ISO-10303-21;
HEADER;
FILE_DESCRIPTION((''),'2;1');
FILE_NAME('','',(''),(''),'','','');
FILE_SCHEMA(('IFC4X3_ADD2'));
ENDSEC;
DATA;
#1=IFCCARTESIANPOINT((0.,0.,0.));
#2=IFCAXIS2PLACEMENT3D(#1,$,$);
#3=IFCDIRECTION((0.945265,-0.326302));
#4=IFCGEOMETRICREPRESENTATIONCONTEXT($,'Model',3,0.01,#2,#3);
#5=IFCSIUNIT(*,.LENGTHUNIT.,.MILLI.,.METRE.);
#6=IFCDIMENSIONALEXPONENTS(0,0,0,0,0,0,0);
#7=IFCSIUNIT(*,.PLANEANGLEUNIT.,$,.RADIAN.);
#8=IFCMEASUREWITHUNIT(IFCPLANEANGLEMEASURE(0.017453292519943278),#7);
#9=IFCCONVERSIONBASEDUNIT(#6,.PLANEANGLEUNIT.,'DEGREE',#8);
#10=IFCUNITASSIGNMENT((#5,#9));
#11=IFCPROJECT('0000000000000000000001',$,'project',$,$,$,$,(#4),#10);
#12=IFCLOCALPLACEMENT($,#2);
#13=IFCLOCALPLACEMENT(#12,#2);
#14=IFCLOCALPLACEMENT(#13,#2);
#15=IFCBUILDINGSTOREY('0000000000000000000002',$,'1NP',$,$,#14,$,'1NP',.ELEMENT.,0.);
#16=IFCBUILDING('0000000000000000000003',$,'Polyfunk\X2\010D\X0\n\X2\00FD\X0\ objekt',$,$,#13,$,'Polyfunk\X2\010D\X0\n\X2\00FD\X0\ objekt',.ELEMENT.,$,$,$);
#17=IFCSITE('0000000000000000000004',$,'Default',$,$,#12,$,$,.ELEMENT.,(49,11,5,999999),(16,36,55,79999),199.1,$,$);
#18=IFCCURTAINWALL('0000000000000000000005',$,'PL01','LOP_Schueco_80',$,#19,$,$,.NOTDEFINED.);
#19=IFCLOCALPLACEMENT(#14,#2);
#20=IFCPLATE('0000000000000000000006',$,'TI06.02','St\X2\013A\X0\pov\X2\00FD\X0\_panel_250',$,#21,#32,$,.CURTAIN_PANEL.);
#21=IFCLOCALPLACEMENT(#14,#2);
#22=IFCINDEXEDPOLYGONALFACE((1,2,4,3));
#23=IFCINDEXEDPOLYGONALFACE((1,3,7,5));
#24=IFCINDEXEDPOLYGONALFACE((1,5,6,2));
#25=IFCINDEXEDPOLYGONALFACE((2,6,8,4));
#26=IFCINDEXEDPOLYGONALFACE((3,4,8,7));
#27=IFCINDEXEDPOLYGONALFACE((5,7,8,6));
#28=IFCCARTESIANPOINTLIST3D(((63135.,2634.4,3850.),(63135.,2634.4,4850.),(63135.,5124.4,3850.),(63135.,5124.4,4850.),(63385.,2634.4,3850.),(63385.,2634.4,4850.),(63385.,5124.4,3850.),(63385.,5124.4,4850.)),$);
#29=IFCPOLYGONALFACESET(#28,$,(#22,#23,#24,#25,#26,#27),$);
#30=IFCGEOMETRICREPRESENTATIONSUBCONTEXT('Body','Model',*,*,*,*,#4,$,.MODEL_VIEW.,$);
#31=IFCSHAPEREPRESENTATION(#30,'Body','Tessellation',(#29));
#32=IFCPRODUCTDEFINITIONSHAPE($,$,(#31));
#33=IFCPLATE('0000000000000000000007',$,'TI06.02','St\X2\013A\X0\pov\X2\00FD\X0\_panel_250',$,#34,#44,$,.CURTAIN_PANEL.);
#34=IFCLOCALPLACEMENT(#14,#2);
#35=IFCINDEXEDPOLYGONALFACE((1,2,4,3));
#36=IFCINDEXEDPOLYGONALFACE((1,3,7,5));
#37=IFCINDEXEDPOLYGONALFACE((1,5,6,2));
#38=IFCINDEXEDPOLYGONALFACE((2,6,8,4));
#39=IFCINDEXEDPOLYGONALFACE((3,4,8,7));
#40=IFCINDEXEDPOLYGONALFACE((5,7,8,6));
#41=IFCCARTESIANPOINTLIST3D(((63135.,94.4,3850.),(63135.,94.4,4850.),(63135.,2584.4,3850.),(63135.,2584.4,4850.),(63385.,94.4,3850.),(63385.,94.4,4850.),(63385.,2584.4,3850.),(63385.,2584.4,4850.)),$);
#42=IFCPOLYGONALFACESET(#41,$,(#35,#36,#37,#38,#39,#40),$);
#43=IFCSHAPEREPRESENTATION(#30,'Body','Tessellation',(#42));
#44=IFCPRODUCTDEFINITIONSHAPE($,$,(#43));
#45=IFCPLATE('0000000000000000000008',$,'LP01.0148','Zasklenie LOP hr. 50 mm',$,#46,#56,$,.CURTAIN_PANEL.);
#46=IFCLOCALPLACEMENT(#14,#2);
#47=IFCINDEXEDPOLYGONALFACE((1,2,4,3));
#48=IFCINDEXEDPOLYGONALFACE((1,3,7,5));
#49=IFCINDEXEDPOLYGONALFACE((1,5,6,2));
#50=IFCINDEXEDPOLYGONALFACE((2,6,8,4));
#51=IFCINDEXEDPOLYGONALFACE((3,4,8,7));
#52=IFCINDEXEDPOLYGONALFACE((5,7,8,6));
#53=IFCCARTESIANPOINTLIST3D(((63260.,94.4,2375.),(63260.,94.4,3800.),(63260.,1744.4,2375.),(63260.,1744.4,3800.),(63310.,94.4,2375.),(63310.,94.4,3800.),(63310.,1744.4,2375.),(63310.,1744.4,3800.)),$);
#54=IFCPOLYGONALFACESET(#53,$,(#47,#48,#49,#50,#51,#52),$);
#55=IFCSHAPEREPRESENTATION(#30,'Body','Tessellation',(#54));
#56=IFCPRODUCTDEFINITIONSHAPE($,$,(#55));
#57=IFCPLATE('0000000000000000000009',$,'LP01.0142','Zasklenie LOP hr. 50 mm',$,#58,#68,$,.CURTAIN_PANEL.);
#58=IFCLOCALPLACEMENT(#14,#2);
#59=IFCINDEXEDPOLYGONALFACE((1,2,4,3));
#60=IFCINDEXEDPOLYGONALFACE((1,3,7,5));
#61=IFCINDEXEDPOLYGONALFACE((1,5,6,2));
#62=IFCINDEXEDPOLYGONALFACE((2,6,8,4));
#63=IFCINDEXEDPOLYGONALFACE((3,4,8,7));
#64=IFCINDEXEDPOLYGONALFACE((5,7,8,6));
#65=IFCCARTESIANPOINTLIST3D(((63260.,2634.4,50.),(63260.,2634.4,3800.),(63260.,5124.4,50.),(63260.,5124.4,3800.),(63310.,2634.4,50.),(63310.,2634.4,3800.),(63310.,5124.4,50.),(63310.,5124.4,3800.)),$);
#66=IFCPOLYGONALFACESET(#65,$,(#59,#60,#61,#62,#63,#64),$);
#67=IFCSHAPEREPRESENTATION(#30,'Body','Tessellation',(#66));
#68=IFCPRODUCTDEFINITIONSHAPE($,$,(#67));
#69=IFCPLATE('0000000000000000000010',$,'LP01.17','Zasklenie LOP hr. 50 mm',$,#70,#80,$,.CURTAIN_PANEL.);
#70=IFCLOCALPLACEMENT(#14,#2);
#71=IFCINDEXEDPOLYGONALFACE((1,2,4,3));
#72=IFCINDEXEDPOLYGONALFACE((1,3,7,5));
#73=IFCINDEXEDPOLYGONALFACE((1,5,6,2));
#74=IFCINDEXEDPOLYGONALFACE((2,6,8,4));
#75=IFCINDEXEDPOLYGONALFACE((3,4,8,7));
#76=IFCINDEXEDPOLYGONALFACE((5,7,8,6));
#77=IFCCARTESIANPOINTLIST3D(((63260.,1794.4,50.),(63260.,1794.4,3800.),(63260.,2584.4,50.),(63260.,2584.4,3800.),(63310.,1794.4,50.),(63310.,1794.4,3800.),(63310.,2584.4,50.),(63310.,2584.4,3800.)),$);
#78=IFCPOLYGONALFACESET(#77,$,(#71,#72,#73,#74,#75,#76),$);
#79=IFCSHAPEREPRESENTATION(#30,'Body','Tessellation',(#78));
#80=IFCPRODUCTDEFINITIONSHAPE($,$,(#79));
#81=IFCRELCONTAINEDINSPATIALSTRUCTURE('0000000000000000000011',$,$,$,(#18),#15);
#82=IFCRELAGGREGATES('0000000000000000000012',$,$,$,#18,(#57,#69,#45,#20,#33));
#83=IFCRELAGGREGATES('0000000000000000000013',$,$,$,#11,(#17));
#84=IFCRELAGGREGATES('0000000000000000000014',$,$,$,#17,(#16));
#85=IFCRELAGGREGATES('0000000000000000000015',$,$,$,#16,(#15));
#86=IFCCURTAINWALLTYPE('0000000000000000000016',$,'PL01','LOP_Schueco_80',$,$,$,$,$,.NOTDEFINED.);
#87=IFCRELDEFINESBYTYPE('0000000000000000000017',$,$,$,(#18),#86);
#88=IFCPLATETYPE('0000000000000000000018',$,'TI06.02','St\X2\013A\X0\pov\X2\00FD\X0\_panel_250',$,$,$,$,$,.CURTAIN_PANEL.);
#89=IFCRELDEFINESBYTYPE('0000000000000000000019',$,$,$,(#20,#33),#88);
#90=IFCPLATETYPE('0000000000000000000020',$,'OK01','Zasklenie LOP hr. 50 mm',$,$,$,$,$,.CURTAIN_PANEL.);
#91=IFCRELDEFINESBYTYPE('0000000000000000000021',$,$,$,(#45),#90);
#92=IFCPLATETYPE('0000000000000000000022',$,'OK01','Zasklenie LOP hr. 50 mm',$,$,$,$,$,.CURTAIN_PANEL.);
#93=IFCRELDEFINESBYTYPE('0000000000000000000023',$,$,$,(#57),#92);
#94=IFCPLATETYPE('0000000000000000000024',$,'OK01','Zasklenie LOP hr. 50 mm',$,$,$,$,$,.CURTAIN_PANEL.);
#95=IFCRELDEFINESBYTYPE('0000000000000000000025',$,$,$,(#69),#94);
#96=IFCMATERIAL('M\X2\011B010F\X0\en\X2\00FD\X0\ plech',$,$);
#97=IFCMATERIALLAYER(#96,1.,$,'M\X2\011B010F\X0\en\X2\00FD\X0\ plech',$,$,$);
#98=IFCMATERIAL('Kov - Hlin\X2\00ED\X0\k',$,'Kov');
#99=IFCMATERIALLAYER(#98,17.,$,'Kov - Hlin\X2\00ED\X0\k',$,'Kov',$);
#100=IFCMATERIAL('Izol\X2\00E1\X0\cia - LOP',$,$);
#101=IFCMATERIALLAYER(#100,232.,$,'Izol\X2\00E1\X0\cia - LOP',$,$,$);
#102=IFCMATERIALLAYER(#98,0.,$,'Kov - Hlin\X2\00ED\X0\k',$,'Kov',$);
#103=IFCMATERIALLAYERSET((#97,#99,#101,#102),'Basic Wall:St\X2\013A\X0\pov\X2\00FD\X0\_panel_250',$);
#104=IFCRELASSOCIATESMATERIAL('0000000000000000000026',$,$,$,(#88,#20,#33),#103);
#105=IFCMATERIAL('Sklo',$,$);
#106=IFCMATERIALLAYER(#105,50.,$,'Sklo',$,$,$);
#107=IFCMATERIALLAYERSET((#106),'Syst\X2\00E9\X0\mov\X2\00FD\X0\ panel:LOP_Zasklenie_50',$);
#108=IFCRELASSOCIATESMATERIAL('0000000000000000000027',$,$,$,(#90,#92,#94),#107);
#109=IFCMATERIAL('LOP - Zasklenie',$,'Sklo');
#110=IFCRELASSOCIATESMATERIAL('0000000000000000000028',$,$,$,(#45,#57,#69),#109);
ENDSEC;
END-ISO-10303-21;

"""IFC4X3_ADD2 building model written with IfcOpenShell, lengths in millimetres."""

from ifc_helpers import new_model, entity, si_unit, converted_unit, direction, frame, frame_2d, origin, origin_2d_with_axis, place, context, subcontext, project, spatial, rectangle, extrude, source, transform, mapped, material, layer, layer_set, layer_usage, type_object, type_shapes, element, aggregate, save


model = new_model("IFC4X3_ADD2")

# Units and contexts
model_context = context("Model", 3, precision=0.01, world=origin(), true_north=direction((0.945265, -0.326302)))
body_context = subcontext(model_context, "Body", "Model", "MODEL_VIEW")
ifc_project = project(units=[si_unit("LENGTHUNIT", "METRE", prefix="MILLI"), converted_unit("PLANEANGLEUNIT", "DEGREE", entity("IfcPlaneAngleMeasure", 0.017453292519943278), si_unit("PLANEANGLEUNIT", "RADIAN"), dimensions=[0, 0, 0, 0, 0, 0, 0])], contexts=[model_context])

# Site, building, storey
site_placement = place(None, origin())
site = spatial("IfcSite", under=ifc_project, at=site_placement, Name="Default", CompositionType="ELEMENT", RefLatitude=(49, 11, 5, 999999), RefLongitude=(16, 36, 55, 79999), RefElevation=199.1)
building_placement = place(site_placement, origin())
building = spatial("IfcBuilding", under=site, at=building_placement, Name="Polyfunkčný objekt", LongName="Polyfunkčný objekt", CompositionType="ELEMENT")
storey_placement = place(building_placement, origin())
storey = spatial("IfcBuildingStorey", under=building, at=storey_placement, Name="1NP", LongName="1NP", CompositionType="ELEMENT", Elevation=0.0)

# Curtain wall, plates
curtain_wall_type = type_object("IfcCurtainWallType", Name="PL01", Description="LOP_Schueco_80", PredefinedType="NOTDEFINED")
curtain_wall_placement = place(storey_placement, origin())
curtain_wall = element("IfcCurtainWall", 1, at=curtain_wall_placement, inside=storey, type_object=curtain_wall_type, Name="PL01", Description="LOP_Schueco_80", PredefinedType="NOTDEFINED")
ifc_material_1 = material(Name="Měďený plech")
ifc_layer_1 = layer(ifc_material_1, 1.0, Name="Měďený plech")
ifc_material_2 = material(Name="Kov - Hliník", Category="Kov")
ifc_layer_2 = layer(ifc_material_2, 17.0, Name="Kov - Hliník", Category="Kov")
ifc_material_3 = material(Name="Izolácia - LOP")
ifc_layer_3 = layer(ifc_material_3, 232.0, Name="Izolácia - LOP")
ifc_layer_4 = layer(ifc_material_2, 0.0, Name="Kov - Hliník", Category="Kov")
ifc_layer_set_1 = layer_set([ifc_layer_1, ifc_layer_2, ifc_layer_3, ifc_layer_4], Name="Basic Wall:Stĺpový_panel_250")
ifc_layer_usage_1 = layer_usage(ifc_layer_set_1, "AXIS2", "NEGATIVE", 125.0)
plate_type_1 = type_object("IfcPlateType", Name="TI06.02", Description="Stĺpový_panel_250", PredefinedType="CURTAIN_PANEL", material=ifc_layer_set_1)
plate_1_placement = place(storey_placement, frame((63260.0, 5124.4, 3850.0), z_axis=(0.0, 0.0, 1.0), x_axis=(0.0, -1.0, 0.0)))
plate_1 = element("IfcPlate", 2, at=plate_1_placement, type_object=plate_type_1, material=ifc_layer_usage_1, Name="TI06.02", Description="Stĺpový_panel_250", PredefinedType="CURTAIN_PANEL", context=body_context, shape_type="SweptSolid", body=[
    extrude(rectangle(XDim=250.0, YDim=2490.0, at=frame_2d((0.0, 0.0), x_axis=(1.0, 0.0))), frame((1245.0, 0.0, 0.0), z_axis=(0.0, 0.0, 1.0), x_axis=(0.0, 1.0, 0.0)), (0.0, 0.0, 1.0), 1000.0),
])
ifc_layer_usage_2 = layer_usage(ifc_layer_set_1, "AXIS2", "NEGATIVE", 125.0)
plate_2_placement = place(storey_placement, frame((63260.0, 2584.4, 3850.0), z_axis=(0.0, 0.0, 1.0), x_axis=(0.0, -1.0, 0.0)))
plate_2 = element("IfcPlate", 3, at=plate_2_placement, type_object=plate_type_1, material=ifc_layer_usage_2, Name="TI06.02", Description="Stĺpový_panel_250", PredefinedType="CURTAIN_PANEL", context=body_context, shape_type="SweptSolid", body=[
    extrude(rectangle(XDim=250.0, YDim=2490.0, at=frame_2d((0.0, 0.0), x_axis=(1.0, 0.0))), frame((1245.0, 0.0, 0.0), z_axis=(0.0, 0.0, 1.0), x_axis=(0.0, 1.0, 0.0)), (0.0, 0.0, 1.0), 1000.0),
])
ifc_material_4 = material(Name="LOP - Zasklenie", Category="Sklo")
ifc_material_5 = material(Name="Sklo")
ifc_layer_5 = layer(ifc_material_5, 50.0, Name="Sklo")
ifc_layer_set_2 = layer_set([ifc_layer_5], Name="Systémový panel:LOP_Zasklenie_50")
plate_type_2 = type_object("IfcPlateType", Name="OK01", Description="Zasklenie LOP hr. 50 mm", PredefinedType="CURTAIN_PANEL", material=ifc_layer_set_2)
shared_shape_1 = source(origin(), body_context, "Body", "SweptSolid", [
    extrude(rectangle(XDim=50.0, YDim=1650.0, at=origin_2d_with_axis()), frame((0.0, 25.0, 0.0), z_axis=(0.0, 0.0, 1.0), x_axis=(0.0, 1.0, 0.0)), (0.0, 0.0, 1.0), 1425.0),
])
type_shapes(plate_type_2, [shared_shape_1])
plate_3_placement = place(curtain_wall_placement, frame((63260.0, 919.4, 2375.0), z_axis=(0.0, 0.0, 1.0), x_axis=(0.0, -1.0, 0.0)))
plate_3 = element("IfcPlate", 4, at=plate_3_placement, type_object=plate_type_2, material=ifc_material_4, Name="LP01.0148", Description="Zasklenie LOP hr. 50 mm", PredefinedType="CURTAIN_PANEL", context=body_context, shape_type="MappedRepresentation", body=[
    mapped(shared_shape_1, transform((0.0, 0.0, 0.0), scale=1.0)),
])
plate_type_3 = type_object("IfcPlateType", Name="OK01", Description="Zasklenie LOP hr. 50 mm", PredefinedType="CURTAIN_PANEL", material=ifc_layer_set_2)
shared_shape_2 = source(origin(), body_context, "Body", "SweptSolid", [
    extrude(rectangle(XDim=3750.0, YDim=2490.0, at=frame_2d((-141.7, 0.0), x_axis=(1.0, 0.0))), frame((0.0, 0.0, 2016.7), z_axis=(0.0, 1.0, 0.0), x_axis=(0.0, 0.0, 1.0)), (0.0, 0.0, 1.0), 50.0),
])
type_shapes(plate_type_3, [shared_shape_2])
plate_4_placement = place(curtain_wall_placement, frame((63260.0, 3879.4, 50.0), z_axis=(0.0, 0.0, 1.0), x_axis=(0.0, -1.0, 0.0)))
plate_4 = element("IfcPlate", 5, at=plate_4_placement, type_object=plate_type_3, material=ifc_material_4, Name="LP01.0142", Description="Zasklenie LOP hr. 50 mm", PredefinedType="CURTAIN_PANEL", context=body_context, shape_type="MappedRepresentation", body=[
    mapped(shared_shape_2, transform((0.0, 0.0, 0.0), scale=1.0)),
])
plate_type_4 = type_object("IfcPlateType", Name="OK01", Description="Zasklenie LOP hr. 50 mm", PredefinedType="CURTAIN_PANEL", material=ifc_layer_set_2)
shared_shape_3 = source(origin(), body_context, "Body", "SweptSolid", [
    extrude(rectangle(XDim=3750.0, YDim=790.0, at=frame_2d((-141.7, 0.0), x_axis=(1.0, 0.0))), frame((0.0, 0.0, 2016.7), z_axis=(0.0, 1.0, 0.0), x_axis=(0.0, 0.0, 1.0)), (0.0, 0.0, 1.0), 50.0),
])
type_shapes(plate_type_4, [shared_shape_3])
plate_5_placement = place(curtain_wall_placement, frame((63260.0, 2189.4, 50.0), z_axis=(0.0, 0.0, 1.0), x_axis=(0.0, -1.0, 0.0)))
plate_5 = element("IfcPlate", 6, at=plate_5_placement, type_object=plate_type_4, material=ifc_material_4, Name="LP01.17", Description="Zasklenie LOP hr. 50 mm", PredefinedType="CURTAIN_PANEL", context=body_context, shape_type="MappedRepresentation", body=[
    mapped(shared_shape_3, transform((0.0, 0.0, 0.0), scale=1.0)),
])
aggregate(curtain_wall, [plate_4, plate_5, plate_3, plate_1, plate_2])

save(model, "model.ifc")
